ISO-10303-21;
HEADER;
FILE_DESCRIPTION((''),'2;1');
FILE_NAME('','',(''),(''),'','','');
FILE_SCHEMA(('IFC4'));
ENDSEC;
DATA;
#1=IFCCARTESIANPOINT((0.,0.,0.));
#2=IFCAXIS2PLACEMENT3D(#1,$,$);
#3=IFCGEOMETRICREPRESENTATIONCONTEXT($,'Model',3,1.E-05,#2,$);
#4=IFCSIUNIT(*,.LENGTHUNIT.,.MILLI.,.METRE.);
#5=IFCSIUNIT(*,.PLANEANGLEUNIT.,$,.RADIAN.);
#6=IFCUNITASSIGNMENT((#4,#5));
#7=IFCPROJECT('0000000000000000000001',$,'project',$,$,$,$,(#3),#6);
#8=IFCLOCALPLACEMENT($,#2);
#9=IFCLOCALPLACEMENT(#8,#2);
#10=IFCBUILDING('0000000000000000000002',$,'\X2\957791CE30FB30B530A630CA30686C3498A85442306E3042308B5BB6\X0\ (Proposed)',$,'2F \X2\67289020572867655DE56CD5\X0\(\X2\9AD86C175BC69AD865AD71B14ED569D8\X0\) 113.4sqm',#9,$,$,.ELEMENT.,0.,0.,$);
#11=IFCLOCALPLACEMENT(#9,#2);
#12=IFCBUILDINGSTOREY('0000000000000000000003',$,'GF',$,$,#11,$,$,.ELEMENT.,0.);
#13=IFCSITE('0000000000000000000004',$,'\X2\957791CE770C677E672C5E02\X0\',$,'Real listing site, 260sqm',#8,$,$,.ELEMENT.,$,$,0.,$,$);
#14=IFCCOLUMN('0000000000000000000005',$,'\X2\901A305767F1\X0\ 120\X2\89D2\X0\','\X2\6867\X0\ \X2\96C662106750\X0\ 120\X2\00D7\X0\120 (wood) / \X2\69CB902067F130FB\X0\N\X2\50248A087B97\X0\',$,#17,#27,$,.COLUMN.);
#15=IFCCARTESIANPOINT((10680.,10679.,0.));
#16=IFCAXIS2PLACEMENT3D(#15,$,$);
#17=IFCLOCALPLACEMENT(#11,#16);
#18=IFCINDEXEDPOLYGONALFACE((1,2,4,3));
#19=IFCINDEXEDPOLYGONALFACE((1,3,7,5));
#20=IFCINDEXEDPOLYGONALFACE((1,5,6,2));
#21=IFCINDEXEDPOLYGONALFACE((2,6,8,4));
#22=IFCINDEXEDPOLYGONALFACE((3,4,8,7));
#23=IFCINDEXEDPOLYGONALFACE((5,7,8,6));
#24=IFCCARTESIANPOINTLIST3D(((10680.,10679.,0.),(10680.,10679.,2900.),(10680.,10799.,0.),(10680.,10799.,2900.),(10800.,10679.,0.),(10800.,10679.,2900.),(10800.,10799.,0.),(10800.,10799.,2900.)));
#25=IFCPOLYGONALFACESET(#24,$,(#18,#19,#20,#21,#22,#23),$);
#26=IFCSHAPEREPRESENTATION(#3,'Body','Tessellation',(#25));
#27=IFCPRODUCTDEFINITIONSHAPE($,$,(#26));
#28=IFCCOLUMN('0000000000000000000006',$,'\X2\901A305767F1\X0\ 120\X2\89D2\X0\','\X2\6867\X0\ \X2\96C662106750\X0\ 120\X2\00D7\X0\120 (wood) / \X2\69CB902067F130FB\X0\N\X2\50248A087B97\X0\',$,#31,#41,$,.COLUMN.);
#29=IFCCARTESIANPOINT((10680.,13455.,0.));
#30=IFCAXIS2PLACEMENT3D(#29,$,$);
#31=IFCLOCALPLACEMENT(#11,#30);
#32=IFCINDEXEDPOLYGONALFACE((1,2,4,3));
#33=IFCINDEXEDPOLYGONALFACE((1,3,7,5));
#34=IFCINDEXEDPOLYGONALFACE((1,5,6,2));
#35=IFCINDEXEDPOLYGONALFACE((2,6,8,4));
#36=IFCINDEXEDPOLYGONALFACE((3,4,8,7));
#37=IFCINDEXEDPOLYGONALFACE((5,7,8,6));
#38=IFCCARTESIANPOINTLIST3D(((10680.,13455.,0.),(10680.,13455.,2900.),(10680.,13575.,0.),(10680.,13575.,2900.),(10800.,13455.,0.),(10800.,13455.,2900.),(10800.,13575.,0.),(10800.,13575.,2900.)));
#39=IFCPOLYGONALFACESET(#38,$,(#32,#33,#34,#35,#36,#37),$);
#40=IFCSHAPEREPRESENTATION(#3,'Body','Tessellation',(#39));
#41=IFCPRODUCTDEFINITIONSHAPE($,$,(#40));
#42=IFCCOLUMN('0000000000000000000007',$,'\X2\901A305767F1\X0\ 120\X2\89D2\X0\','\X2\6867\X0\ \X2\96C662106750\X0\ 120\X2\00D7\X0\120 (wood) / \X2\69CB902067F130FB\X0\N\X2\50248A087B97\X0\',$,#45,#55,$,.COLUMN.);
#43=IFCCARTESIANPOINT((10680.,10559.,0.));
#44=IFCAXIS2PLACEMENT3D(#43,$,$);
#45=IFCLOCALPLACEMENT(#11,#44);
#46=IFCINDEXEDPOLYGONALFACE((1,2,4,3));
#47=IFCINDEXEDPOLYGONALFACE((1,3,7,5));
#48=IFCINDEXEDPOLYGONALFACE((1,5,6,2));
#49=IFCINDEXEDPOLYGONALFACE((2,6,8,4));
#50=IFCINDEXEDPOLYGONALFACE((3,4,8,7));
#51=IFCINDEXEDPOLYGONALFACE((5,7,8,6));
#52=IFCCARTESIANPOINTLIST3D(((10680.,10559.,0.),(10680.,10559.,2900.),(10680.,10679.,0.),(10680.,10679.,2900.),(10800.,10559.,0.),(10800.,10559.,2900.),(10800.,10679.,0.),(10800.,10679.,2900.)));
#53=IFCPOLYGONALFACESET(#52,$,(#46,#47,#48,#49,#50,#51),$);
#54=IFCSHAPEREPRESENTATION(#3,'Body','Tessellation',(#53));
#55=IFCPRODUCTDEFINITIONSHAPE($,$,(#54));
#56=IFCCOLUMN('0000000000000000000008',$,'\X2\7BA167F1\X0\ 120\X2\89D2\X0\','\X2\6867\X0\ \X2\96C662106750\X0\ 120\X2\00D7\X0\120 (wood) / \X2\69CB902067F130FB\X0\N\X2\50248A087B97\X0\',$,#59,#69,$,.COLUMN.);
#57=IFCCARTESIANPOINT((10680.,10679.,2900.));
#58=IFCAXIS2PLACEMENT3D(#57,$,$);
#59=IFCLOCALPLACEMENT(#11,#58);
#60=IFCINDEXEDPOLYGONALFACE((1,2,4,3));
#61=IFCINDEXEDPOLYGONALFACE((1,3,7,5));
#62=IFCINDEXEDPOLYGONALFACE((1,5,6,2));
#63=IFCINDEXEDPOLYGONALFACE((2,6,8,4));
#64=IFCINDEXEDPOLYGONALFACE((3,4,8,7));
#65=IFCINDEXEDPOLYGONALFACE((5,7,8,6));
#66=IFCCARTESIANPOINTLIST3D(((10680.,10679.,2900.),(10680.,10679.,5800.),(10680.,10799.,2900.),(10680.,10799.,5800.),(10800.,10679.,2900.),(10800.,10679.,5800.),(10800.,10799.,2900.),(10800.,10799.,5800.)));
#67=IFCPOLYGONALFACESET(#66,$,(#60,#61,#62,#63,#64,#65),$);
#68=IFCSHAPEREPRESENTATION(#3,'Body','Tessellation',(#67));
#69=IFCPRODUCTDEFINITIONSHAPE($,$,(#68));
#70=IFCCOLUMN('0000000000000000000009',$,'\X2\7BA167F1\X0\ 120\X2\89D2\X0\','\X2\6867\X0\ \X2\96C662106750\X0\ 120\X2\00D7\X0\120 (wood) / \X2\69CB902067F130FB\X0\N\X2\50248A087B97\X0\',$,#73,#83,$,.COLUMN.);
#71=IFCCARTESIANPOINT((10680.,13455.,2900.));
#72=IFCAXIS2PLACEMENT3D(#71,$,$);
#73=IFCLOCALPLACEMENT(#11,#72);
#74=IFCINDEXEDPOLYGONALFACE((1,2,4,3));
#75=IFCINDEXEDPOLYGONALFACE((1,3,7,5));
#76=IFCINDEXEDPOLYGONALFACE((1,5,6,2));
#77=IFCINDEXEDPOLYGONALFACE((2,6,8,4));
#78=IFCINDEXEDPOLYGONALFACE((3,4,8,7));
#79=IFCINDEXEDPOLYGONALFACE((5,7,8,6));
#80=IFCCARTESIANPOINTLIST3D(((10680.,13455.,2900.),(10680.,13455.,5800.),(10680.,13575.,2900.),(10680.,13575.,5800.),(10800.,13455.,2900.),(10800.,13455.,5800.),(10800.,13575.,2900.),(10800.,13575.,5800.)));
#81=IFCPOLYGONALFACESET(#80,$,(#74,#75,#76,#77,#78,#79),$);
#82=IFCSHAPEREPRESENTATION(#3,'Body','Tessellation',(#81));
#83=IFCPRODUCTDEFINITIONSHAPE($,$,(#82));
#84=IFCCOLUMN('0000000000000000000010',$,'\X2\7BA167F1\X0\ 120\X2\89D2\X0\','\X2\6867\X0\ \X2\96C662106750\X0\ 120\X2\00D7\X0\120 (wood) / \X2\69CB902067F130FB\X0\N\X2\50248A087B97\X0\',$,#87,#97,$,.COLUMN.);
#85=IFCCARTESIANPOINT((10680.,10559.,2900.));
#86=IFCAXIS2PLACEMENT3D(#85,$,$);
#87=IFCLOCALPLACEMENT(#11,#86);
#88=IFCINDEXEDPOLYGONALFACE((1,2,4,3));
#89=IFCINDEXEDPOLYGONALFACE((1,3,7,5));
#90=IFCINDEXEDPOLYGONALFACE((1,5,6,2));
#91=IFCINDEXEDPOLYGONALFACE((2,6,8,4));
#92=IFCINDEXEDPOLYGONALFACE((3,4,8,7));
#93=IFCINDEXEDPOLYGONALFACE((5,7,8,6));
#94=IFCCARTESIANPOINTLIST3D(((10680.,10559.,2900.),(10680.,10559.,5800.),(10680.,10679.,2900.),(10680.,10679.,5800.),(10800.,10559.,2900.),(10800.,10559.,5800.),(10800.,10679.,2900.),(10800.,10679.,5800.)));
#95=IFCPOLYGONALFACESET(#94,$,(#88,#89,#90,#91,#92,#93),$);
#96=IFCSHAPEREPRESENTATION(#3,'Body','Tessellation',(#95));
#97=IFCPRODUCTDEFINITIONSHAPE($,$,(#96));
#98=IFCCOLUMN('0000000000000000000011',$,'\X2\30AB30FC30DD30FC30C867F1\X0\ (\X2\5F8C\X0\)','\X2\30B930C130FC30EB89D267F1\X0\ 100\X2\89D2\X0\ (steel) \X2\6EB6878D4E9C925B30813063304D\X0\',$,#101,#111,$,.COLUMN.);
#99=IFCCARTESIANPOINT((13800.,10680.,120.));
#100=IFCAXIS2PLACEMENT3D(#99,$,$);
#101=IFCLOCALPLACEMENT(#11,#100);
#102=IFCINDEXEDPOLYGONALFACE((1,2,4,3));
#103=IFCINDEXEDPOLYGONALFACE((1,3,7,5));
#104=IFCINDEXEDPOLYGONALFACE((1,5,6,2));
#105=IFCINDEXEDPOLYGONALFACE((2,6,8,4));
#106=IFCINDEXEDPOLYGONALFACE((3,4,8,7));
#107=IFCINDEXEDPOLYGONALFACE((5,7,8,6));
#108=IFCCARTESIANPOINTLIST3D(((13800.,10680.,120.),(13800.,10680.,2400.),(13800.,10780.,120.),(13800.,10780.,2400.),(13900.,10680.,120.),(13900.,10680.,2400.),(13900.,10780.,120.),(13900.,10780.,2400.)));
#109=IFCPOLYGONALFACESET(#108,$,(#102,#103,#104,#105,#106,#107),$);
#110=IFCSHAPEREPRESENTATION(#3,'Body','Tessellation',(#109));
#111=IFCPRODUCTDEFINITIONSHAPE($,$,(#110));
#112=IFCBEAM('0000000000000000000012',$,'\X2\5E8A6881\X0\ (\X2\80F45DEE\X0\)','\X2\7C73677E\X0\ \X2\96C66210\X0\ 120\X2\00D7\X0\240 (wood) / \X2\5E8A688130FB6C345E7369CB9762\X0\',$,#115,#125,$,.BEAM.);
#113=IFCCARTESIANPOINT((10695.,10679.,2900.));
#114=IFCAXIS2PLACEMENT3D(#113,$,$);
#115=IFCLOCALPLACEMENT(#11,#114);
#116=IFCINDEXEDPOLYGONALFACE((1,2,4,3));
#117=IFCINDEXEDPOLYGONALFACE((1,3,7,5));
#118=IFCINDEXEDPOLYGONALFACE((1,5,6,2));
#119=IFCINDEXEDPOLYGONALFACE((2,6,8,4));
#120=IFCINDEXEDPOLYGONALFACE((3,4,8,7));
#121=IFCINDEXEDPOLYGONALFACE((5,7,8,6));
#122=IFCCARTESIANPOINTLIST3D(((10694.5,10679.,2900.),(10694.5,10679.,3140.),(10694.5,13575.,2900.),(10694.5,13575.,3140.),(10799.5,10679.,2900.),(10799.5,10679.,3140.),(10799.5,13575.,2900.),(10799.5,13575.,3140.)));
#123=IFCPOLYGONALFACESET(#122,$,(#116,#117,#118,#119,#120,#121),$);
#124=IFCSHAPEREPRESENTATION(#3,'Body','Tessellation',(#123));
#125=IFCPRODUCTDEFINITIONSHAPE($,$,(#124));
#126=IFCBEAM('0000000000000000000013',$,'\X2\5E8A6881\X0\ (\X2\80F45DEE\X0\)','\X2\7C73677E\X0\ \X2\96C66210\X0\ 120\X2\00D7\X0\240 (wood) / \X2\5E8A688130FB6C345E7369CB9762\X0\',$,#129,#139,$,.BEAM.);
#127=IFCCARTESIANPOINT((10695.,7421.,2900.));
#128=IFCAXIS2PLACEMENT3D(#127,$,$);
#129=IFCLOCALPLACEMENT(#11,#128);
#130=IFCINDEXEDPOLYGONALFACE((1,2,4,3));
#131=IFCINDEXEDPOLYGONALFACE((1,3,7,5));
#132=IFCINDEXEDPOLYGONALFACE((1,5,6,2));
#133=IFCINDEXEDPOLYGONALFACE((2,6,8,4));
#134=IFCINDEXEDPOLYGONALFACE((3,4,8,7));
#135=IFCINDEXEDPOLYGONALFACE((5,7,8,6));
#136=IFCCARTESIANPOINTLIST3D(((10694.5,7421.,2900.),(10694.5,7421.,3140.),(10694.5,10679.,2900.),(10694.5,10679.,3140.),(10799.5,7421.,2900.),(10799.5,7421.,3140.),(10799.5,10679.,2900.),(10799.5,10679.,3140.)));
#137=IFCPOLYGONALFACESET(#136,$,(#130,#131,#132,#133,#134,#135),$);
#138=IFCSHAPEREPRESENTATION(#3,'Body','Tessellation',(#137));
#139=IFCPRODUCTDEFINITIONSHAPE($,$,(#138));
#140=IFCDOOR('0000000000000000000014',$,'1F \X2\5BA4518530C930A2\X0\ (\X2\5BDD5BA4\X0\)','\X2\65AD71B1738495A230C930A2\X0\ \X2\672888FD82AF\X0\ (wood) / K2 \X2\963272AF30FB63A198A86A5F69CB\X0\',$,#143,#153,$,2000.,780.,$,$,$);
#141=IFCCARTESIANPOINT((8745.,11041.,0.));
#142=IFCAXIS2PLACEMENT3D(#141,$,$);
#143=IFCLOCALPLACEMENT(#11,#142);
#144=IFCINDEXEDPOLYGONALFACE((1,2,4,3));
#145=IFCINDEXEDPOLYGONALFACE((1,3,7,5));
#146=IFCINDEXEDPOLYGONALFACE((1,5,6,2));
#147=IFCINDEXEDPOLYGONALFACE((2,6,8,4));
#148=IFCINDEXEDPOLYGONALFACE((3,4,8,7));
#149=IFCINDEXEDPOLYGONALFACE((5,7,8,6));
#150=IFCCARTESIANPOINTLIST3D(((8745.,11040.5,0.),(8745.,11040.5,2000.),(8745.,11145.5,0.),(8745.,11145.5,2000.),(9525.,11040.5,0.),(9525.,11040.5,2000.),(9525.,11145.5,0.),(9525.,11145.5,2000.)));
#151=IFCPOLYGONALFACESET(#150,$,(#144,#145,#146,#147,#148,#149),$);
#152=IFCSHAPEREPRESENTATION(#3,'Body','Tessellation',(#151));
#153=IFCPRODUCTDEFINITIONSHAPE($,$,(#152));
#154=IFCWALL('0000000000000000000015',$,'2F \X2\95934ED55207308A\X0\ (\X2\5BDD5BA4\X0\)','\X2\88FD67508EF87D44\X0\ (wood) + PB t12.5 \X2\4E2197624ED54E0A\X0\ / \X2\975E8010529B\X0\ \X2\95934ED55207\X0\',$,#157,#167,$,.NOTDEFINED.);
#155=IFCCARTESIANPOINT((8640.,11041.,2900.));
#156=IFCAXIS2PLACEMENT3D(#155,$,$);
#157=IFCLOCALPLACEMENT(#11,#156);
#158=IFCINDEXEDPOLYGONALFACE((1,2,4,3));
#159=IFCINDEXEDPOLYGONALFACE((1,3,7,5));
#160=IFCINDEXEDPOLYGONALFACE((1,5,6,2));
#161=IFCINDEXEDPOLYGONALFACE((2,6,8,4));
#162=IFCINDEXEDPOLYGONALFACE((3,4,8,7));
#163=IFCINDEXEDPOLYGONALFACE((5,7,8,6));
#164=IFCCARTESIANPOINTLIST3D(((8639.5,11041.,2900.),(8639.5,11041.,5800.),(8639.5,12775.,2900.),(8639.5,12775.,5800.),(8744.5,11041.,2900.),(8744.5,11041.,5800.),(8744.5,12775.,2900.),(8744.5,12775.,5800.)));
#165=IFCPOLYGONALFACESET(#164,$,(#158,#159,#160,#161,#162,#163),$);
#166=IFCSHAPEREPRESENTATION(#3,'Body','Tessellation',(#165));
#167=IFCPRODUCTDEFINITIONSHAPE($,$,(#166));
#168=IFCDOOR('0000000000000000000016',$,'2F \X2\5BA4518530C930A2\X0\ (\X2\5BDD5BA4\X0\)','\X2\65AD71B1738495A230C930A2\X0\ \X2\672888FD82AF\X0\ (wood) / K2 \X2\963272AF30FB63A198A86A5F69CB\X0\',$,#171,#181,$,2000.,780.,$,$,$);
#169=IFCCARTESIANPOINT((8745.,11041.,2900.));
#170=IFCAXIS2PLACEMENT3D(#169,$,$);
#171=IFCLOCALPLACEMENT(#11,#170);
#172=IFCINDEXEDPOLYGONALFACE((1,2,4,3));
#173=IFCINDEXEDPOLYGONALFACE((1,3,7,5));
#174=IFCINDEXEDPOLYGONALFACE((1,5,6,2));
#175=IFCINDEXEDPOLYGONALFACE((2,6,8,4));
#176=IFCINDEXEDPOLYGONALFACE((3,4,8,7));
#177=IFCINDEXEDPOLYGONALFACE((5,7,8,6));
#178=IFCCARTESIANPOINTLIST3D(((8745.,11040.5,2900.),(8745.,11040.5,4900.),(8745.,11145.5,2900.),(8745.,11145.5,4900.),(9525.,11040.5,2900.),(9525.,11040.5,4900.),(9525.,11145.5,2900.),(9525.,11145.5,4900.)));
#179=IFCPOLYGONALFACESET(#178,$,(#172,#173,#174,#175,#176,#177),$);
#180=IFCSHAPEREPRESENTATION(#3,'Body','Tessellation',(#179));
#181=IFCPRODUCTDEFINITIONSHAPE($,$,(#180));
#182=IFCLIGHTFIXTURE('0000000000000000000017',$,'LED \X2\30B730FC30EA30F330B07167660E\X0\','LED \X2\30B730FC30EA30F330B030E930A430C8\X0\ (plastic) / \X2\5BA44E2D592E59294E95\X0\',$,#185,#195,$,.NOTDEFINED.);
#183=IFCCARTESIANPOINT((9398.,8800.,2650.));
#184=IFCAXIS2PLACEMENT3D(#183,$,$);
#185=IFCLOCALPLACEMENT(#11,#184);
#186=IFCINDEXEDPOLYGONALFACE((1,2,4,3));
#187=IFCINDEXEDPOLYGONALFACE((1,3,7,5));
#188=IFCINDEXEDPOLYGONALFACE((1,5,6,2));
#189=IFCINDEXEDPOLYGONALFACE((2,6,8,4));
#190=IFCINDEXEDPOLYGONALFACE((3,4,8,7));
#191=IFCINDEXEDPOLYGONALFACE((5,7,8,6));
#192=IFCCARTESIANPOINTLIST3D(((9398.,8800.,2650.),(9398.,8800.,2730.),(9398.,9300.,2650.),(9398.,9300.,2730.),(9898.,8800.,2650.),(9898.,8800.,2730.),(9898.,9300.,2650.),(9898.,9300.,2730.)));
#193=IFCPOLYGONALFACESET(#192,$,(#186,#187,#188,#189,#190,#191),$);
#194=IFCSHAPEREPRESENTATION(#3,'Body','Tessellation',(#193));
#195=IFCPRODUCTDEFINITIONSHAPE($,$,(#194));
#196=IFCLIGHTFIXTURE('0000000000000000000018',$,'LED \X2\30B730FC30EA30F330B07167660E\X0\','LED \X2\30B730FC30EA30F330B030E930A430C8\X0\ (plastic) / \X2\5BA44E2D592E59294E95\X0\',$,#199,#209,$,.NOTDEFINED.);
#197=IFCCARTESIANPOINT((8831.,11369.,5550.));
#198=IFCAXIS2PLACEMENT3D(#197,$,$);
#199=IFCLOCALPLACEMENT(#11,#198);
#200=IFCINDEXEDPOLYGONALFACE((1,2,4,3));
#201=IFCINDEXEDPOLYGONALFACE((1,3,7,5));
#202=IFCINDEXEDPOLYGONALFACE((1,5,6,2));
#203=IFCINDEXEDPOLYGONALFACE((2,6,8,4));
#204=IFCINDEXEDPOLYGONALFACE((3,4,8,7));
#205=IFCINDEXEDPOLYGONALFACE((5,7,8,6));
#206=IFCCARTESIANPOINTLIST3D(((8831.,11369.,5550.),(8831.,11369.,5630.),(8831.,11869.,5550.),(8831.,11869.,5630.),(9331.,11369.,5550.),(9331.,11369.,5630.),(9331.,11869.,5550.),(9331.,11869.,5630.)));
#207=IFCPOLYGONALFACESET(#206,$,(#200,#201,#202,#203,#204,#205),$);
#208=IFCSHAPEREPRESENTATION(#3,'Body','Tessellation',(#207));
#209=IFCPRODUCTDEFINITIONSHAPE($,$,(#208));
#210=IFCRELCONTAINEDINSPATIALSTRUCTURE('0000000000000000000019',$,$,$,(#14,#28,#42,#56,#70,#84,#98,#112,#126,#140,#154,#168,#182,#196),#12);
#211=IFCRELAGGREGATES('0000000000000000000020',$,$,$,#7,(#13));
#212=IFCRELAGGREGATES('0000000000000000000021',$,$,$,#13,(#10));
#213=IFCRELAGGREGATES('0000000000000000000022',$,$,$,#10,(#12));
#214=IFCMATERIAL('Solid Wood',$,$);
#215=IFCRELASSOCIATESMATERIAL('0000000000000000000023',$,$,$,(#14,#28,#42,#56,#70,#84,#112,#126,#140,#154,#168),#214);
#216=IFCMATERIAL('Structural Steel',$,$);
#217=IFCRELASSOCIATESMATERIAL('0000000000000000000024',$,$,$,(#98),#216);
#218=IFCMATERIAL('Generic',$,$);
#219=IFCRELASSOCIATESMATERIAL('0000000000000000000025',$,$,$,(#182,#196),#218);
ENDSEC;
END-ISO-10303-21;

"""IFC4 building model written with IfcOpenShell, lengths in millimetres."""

from ifc_helpers import new_model, si_unit, frame, frame_2d, origin, place, context, project, spatial, rectangle, extrude, material, element, save


model = new_model("IFC4")

# Units and contexts
model_context = context("Model", 3, precision=1e-05, world=origin())
ifc_project = project(units=[si_unit("LENGTHUNIT", "METRE", prefix="MILLI"), si_unit("PLANEANGLEUNIT", "RADIAN")], contexts=[model_context])

# Site, building, storey
site_placement = place(None, origin())
site = spatial("IfcSite", under=ifc_project, at=site_placement, Name="長野県松本市", ObjectType="Real listing site, 260sqm", CompositionType="ELEMENT", RefElevation=0.0)
building_placement = place(site_placement, origin())
building = spatial("IfcBuilding", under=site, at=building_placement, Name="長野・サウナと水風呂のある家 (Proposed)", ObjectType="2F 木造在来工法(高気密高断熱仕様) 113.4sqm", CompositionType="ELEMENT", ElevationOfRefHeight=0.0, ElevationOfTerrain=0.0)
storey_placement = place(building_placement, origin())
storey = spatial("IfcBuildingStorey", under=building, at=storey_placement, Name="GF", CompositionType="ELEMENT", Elevation=0.0)

# Columns
ifc_material_1 = material(Name="Solid Wood")
column_1_placement = place(storey_placement, frame((10680.0, 10679.0, 0.0)))
element("IfcColumn", 1, at=column_1_placement, inside=storey, material=ifc_material_1, Name="通し柱 120角", Description="桧 集成材 120×120 (wood) / 構造柱・N値計算", PredefinedType="COLUMN", context=model_context, shape_type="SweptSolid", body=[
    extrude(rectangle(XDim=120.0, YDim=120.0, at=frame_2d((60.0, 60.0))), frame((10680.0, 10679.0, 0.0)), (0.0, 0.0, 1.0), 2900.0),
])
column_2_placement = place(storey_placement, frame((10680.0, 13455.0, 0.0)))
element("IfcColumn", 2, at=column_2_placement, inside=storey, material=ifc_material_1, Name="通し柱 120角", Description="桧 集成材 120×120 (wood) / 構造柱・N値計算", PredefinedType="COLUMN", context=model_context, shape_type="SweptSolid", body=[
    extrude(rectangle(XDim=120.0, YDim=120.0, at=frame_2d((60.0, 60.0))), frame((10680.0, 13455.0, 0.0)), (0.0, 0.0, 1.0), 2900.0),
])
column_3_placement = place(storey_placement, frame((10680.0, 10559.0, 0.0)))
element("IfcColumn", 3, at=column_3_placement, inside=storey, material=ifc_material_1, Name="通し柱 120角", Description="桧 集成材 120×120 (wood) / 構造柱・N値計算", PredefinedType="COLUMN", context=model_context, shape_type="SweptSolid", body=[
    extrude(rectangle(XDim=120.0, YDim=120.0, at=frame_2d((60.0, 60.0))), frame((10680.0, 10559.0, 0.0)), (0.0, 0.0, 1.0), 2900.0),
])
column_4_placement = place(storey_placement, frame((10680.0, 10679.0, 2900.0)))
element("IfcColumn", 4, at=column_4_placement, inside=storey, material=ifc_material_1, Name="管柱 120角", Description="桧 集成材 120×120 (wood) / 構造柱・N値計算", PredefinedType="COLUMN", context=model_context, shape_type="SweptSolid", body=[
    extrude(rectangle(XDim=120.0, YDim=120.0, at=frame_2d((60.0, 60.0))), frame((10680.0, 10679.0, 2900.0)), (0.0, 0.0, 1.0), 2900.0),
])
column_5_placement = place(storey_placement, frame((10680.0, 13455.0, 2900.0)))
element("IfcColumn", 5, at=column_5_placement, inside=storey, material=ifc_material_1, Name="管柱 120角", Description="桧 集成材 120×120 (wood) / 構造柱・N値計算", PredefinedType="COLUMN", context=model_context, shape_type="SweptSolid", body=[
    extrude(rectangle(XDim=120.0, YDim=120.0, at=frame_2d((60.0, 60.0))), frame((10680.0, 13455.0, 2900.0)), (0.0, 0.0, 1.0), 2900.0),
])
column_6_placement = place(storey_placement, frame((10680.0, 10559.0, 2900.0)))
element("IfcColumn", 6, at=column_6_placement, inside=storey, material=ifc_material_1, Name="管柱 120角", Description="桧 集成材 120×120 (wood) / 構造柱・N値計算", PredefinedType="COLUMN", context=model_context, shape_type="SweptSolid", body=[
    extrude(rectangle(XDim=120.0, YDim=120.0, at=frame_2d((60.0, 60.0))), frame((10680.0, 10559.0, 2900.0)), (0.0, 0.0, 1.0), 2900.0),
])
ifc_material_2 = material(Name="Structural Steel")
column_7_placement = place(storey_placement, frame((13800.0, 10680.0, 120.0)))
element("IfcColumn", 7, at=column_7_placement, inside=storey, material=ifc_material_2, Name="カーポート柱 (後)", Description="スチール角柱 100角 (steel) 溶融亜鉛めっき", PredefinedType="COLUMN", context=model_context, shape_type="SweptSolid", body=[
    extrude(rectangle(XDim=100.0, YDim=100.0, at=frame_2d((50.0, 50.0))), frame((13800.0, 10680.0, 120.0)), (0.0, 0.0, 1.0), 2280.0),
])

# Beams
beam_1_placement = place(storey_placement, frame((10695.0, 10679.0, 2900.0)))
element("IfcBeam", 8, at=beam_1_placement, inside=storey, material=ifc_material_1, Name="床梁 (胴差)", Description="米松 集成 120×240 (wood) / 床梁・水平構面", PredefinedType="BEAM", context=model_context, shape_type="SweptSolid", body=[
    extrude(rectangle(XDim=105.0, YDim=2896.0, at=frame_2d((52.0, 1448.0))), frame((10695.0, 10679.0, 2900.0)), (0.0, 0.0, 1.0), 240.0),
])
beam_2_placement = place(storey_placement, frame((10695.0, 7421.0, 2900.0)))
element("IfcBeam", 9, at=beam_2_placement, inside=storey, material=ifc_material_1, Name="床梁 (胴差)", Description="米松 集成 120×240 (wood) / 床梁・水平構面", PredefinedType="BEAM", context=model_context, shape_type="SweptSolid", body=[
    extrude(rectangle(XDim=105.0, YDim=3258.0, at=frame_2d((52.0, 1629.0))), frame((10695.0, 7421.0, 2900.0)), (0.0, 0.0, 1.0), 240.0),
])

# Door
door_1_placement = place(storey_placement, frame((8745.0, 11041.0, 0.0)))
element("IfcDoor", 10, at=door_1_placement, inside=storey, material=ifc_material_1, Name="1F 室内ドア (寝室)", Description="断熱玄関ドア 木製芯 (wood) / K2 防犯・採風機構", OverallHeight=2000.0, OverallWidth=780.0, context=model_context, shape_type="SweptSolid", body=[
    extrude(rectangle(XDim=780.0, YDim=105.0, at=frame_2d((390.0, 52.0))), frame((8745.0, 11041.0, 0.0)), (0.0, 0.0, 1.0), 2000.0),
])

# Wall
wall_placement = place(storey_placement, frame((8640.0, 11041.0, 2900.0)))
element("IfcWall", 11, at=wall_placement, inside=storey, material=ifc_material_1, Name="2F 間仕切り (寝室)", Description="製材軸組 (wood) + PB t12.5 両面仕上 / 非耐力 間仕切", PredefinedType="NOTDEFINED", context=model_context, shape_type="SweptSolid", body=[
    extrude(rectangle(XDim=105.0, YDim=1734.0, at=frame_2d((52.0, 867.0))), frame((8640.0, 11041.0, 2900.0)), (0.0, 0.0, 1.0), 2900.0),
])

# Door
door_2_placement = place(storey_placement, frame((8745.0, 11041.0, 2900.0)))
element("IfcDoor", 12, at=door_2_placement, inside=storey, material=ifc_material_1, Name="2F 室内ドア (寝室)", Description="断熱玄関ドア 木製芯 (wood) / K2 防犯・採風機構", OverallHeight=2000.0, OverallWidth=780.0, context=model_context, shape_type="SweptSolid", body=[
    extrude(rectangle(XDim=780.0, YDim=105.0, at=frame_2d((390.0, 52.0))), frame((8745.0, 11041.0, 2900.0)), (0.0, 0.0, 1.0), 2000.0),
])

# Light fixtures
ifc_material_3 = material(Name="Generic")
light_fixture_1_placement = place(storey_placement, frame((9398.0, 8800.0, 2650.0)))
element("IfcLightFixture", 13, at=light_fixture_1_placement, inside=storey, material=ifc_material_3, Name="LED シーリング照明", Description="LED シーリングライト (plastic) / 室中央天井", PredefinedType="NOTDEFINED", context=model_context, shape_type="SweptSolid", body=[
    extrude(rectangle(XDim=500.0, YDim=500.0, at=frame_2d((250.0, 250.0))), frame((9398.0, 8800.0, 2650.0)), (0.0, 0.0, 1.0), 80.0),
])
light_fixture_2_placement = place(storey_placement, frame((8831.0, 11369.0, 5550.0)))
element("IfcLightFixture", 14, at=light_fixture_2_placement, inside=storey, material=ifc_material_3, Name="LED シーリング照明", Description="LED シーリングライト (plastic) / 室中央天井", PredefinedType="NOTDEFINED", context=model_context, shape_type="SweptSolid", body=[
    extrude(rectangle(XDim=500.0, YDim=500.0, at=frame_2d((250.0, 250.0))), frame((8831.0, 11369.0, 5550.0)), (0.0, 0.0, 1.0), 80.0),
])

save(model, "model.ifc")
